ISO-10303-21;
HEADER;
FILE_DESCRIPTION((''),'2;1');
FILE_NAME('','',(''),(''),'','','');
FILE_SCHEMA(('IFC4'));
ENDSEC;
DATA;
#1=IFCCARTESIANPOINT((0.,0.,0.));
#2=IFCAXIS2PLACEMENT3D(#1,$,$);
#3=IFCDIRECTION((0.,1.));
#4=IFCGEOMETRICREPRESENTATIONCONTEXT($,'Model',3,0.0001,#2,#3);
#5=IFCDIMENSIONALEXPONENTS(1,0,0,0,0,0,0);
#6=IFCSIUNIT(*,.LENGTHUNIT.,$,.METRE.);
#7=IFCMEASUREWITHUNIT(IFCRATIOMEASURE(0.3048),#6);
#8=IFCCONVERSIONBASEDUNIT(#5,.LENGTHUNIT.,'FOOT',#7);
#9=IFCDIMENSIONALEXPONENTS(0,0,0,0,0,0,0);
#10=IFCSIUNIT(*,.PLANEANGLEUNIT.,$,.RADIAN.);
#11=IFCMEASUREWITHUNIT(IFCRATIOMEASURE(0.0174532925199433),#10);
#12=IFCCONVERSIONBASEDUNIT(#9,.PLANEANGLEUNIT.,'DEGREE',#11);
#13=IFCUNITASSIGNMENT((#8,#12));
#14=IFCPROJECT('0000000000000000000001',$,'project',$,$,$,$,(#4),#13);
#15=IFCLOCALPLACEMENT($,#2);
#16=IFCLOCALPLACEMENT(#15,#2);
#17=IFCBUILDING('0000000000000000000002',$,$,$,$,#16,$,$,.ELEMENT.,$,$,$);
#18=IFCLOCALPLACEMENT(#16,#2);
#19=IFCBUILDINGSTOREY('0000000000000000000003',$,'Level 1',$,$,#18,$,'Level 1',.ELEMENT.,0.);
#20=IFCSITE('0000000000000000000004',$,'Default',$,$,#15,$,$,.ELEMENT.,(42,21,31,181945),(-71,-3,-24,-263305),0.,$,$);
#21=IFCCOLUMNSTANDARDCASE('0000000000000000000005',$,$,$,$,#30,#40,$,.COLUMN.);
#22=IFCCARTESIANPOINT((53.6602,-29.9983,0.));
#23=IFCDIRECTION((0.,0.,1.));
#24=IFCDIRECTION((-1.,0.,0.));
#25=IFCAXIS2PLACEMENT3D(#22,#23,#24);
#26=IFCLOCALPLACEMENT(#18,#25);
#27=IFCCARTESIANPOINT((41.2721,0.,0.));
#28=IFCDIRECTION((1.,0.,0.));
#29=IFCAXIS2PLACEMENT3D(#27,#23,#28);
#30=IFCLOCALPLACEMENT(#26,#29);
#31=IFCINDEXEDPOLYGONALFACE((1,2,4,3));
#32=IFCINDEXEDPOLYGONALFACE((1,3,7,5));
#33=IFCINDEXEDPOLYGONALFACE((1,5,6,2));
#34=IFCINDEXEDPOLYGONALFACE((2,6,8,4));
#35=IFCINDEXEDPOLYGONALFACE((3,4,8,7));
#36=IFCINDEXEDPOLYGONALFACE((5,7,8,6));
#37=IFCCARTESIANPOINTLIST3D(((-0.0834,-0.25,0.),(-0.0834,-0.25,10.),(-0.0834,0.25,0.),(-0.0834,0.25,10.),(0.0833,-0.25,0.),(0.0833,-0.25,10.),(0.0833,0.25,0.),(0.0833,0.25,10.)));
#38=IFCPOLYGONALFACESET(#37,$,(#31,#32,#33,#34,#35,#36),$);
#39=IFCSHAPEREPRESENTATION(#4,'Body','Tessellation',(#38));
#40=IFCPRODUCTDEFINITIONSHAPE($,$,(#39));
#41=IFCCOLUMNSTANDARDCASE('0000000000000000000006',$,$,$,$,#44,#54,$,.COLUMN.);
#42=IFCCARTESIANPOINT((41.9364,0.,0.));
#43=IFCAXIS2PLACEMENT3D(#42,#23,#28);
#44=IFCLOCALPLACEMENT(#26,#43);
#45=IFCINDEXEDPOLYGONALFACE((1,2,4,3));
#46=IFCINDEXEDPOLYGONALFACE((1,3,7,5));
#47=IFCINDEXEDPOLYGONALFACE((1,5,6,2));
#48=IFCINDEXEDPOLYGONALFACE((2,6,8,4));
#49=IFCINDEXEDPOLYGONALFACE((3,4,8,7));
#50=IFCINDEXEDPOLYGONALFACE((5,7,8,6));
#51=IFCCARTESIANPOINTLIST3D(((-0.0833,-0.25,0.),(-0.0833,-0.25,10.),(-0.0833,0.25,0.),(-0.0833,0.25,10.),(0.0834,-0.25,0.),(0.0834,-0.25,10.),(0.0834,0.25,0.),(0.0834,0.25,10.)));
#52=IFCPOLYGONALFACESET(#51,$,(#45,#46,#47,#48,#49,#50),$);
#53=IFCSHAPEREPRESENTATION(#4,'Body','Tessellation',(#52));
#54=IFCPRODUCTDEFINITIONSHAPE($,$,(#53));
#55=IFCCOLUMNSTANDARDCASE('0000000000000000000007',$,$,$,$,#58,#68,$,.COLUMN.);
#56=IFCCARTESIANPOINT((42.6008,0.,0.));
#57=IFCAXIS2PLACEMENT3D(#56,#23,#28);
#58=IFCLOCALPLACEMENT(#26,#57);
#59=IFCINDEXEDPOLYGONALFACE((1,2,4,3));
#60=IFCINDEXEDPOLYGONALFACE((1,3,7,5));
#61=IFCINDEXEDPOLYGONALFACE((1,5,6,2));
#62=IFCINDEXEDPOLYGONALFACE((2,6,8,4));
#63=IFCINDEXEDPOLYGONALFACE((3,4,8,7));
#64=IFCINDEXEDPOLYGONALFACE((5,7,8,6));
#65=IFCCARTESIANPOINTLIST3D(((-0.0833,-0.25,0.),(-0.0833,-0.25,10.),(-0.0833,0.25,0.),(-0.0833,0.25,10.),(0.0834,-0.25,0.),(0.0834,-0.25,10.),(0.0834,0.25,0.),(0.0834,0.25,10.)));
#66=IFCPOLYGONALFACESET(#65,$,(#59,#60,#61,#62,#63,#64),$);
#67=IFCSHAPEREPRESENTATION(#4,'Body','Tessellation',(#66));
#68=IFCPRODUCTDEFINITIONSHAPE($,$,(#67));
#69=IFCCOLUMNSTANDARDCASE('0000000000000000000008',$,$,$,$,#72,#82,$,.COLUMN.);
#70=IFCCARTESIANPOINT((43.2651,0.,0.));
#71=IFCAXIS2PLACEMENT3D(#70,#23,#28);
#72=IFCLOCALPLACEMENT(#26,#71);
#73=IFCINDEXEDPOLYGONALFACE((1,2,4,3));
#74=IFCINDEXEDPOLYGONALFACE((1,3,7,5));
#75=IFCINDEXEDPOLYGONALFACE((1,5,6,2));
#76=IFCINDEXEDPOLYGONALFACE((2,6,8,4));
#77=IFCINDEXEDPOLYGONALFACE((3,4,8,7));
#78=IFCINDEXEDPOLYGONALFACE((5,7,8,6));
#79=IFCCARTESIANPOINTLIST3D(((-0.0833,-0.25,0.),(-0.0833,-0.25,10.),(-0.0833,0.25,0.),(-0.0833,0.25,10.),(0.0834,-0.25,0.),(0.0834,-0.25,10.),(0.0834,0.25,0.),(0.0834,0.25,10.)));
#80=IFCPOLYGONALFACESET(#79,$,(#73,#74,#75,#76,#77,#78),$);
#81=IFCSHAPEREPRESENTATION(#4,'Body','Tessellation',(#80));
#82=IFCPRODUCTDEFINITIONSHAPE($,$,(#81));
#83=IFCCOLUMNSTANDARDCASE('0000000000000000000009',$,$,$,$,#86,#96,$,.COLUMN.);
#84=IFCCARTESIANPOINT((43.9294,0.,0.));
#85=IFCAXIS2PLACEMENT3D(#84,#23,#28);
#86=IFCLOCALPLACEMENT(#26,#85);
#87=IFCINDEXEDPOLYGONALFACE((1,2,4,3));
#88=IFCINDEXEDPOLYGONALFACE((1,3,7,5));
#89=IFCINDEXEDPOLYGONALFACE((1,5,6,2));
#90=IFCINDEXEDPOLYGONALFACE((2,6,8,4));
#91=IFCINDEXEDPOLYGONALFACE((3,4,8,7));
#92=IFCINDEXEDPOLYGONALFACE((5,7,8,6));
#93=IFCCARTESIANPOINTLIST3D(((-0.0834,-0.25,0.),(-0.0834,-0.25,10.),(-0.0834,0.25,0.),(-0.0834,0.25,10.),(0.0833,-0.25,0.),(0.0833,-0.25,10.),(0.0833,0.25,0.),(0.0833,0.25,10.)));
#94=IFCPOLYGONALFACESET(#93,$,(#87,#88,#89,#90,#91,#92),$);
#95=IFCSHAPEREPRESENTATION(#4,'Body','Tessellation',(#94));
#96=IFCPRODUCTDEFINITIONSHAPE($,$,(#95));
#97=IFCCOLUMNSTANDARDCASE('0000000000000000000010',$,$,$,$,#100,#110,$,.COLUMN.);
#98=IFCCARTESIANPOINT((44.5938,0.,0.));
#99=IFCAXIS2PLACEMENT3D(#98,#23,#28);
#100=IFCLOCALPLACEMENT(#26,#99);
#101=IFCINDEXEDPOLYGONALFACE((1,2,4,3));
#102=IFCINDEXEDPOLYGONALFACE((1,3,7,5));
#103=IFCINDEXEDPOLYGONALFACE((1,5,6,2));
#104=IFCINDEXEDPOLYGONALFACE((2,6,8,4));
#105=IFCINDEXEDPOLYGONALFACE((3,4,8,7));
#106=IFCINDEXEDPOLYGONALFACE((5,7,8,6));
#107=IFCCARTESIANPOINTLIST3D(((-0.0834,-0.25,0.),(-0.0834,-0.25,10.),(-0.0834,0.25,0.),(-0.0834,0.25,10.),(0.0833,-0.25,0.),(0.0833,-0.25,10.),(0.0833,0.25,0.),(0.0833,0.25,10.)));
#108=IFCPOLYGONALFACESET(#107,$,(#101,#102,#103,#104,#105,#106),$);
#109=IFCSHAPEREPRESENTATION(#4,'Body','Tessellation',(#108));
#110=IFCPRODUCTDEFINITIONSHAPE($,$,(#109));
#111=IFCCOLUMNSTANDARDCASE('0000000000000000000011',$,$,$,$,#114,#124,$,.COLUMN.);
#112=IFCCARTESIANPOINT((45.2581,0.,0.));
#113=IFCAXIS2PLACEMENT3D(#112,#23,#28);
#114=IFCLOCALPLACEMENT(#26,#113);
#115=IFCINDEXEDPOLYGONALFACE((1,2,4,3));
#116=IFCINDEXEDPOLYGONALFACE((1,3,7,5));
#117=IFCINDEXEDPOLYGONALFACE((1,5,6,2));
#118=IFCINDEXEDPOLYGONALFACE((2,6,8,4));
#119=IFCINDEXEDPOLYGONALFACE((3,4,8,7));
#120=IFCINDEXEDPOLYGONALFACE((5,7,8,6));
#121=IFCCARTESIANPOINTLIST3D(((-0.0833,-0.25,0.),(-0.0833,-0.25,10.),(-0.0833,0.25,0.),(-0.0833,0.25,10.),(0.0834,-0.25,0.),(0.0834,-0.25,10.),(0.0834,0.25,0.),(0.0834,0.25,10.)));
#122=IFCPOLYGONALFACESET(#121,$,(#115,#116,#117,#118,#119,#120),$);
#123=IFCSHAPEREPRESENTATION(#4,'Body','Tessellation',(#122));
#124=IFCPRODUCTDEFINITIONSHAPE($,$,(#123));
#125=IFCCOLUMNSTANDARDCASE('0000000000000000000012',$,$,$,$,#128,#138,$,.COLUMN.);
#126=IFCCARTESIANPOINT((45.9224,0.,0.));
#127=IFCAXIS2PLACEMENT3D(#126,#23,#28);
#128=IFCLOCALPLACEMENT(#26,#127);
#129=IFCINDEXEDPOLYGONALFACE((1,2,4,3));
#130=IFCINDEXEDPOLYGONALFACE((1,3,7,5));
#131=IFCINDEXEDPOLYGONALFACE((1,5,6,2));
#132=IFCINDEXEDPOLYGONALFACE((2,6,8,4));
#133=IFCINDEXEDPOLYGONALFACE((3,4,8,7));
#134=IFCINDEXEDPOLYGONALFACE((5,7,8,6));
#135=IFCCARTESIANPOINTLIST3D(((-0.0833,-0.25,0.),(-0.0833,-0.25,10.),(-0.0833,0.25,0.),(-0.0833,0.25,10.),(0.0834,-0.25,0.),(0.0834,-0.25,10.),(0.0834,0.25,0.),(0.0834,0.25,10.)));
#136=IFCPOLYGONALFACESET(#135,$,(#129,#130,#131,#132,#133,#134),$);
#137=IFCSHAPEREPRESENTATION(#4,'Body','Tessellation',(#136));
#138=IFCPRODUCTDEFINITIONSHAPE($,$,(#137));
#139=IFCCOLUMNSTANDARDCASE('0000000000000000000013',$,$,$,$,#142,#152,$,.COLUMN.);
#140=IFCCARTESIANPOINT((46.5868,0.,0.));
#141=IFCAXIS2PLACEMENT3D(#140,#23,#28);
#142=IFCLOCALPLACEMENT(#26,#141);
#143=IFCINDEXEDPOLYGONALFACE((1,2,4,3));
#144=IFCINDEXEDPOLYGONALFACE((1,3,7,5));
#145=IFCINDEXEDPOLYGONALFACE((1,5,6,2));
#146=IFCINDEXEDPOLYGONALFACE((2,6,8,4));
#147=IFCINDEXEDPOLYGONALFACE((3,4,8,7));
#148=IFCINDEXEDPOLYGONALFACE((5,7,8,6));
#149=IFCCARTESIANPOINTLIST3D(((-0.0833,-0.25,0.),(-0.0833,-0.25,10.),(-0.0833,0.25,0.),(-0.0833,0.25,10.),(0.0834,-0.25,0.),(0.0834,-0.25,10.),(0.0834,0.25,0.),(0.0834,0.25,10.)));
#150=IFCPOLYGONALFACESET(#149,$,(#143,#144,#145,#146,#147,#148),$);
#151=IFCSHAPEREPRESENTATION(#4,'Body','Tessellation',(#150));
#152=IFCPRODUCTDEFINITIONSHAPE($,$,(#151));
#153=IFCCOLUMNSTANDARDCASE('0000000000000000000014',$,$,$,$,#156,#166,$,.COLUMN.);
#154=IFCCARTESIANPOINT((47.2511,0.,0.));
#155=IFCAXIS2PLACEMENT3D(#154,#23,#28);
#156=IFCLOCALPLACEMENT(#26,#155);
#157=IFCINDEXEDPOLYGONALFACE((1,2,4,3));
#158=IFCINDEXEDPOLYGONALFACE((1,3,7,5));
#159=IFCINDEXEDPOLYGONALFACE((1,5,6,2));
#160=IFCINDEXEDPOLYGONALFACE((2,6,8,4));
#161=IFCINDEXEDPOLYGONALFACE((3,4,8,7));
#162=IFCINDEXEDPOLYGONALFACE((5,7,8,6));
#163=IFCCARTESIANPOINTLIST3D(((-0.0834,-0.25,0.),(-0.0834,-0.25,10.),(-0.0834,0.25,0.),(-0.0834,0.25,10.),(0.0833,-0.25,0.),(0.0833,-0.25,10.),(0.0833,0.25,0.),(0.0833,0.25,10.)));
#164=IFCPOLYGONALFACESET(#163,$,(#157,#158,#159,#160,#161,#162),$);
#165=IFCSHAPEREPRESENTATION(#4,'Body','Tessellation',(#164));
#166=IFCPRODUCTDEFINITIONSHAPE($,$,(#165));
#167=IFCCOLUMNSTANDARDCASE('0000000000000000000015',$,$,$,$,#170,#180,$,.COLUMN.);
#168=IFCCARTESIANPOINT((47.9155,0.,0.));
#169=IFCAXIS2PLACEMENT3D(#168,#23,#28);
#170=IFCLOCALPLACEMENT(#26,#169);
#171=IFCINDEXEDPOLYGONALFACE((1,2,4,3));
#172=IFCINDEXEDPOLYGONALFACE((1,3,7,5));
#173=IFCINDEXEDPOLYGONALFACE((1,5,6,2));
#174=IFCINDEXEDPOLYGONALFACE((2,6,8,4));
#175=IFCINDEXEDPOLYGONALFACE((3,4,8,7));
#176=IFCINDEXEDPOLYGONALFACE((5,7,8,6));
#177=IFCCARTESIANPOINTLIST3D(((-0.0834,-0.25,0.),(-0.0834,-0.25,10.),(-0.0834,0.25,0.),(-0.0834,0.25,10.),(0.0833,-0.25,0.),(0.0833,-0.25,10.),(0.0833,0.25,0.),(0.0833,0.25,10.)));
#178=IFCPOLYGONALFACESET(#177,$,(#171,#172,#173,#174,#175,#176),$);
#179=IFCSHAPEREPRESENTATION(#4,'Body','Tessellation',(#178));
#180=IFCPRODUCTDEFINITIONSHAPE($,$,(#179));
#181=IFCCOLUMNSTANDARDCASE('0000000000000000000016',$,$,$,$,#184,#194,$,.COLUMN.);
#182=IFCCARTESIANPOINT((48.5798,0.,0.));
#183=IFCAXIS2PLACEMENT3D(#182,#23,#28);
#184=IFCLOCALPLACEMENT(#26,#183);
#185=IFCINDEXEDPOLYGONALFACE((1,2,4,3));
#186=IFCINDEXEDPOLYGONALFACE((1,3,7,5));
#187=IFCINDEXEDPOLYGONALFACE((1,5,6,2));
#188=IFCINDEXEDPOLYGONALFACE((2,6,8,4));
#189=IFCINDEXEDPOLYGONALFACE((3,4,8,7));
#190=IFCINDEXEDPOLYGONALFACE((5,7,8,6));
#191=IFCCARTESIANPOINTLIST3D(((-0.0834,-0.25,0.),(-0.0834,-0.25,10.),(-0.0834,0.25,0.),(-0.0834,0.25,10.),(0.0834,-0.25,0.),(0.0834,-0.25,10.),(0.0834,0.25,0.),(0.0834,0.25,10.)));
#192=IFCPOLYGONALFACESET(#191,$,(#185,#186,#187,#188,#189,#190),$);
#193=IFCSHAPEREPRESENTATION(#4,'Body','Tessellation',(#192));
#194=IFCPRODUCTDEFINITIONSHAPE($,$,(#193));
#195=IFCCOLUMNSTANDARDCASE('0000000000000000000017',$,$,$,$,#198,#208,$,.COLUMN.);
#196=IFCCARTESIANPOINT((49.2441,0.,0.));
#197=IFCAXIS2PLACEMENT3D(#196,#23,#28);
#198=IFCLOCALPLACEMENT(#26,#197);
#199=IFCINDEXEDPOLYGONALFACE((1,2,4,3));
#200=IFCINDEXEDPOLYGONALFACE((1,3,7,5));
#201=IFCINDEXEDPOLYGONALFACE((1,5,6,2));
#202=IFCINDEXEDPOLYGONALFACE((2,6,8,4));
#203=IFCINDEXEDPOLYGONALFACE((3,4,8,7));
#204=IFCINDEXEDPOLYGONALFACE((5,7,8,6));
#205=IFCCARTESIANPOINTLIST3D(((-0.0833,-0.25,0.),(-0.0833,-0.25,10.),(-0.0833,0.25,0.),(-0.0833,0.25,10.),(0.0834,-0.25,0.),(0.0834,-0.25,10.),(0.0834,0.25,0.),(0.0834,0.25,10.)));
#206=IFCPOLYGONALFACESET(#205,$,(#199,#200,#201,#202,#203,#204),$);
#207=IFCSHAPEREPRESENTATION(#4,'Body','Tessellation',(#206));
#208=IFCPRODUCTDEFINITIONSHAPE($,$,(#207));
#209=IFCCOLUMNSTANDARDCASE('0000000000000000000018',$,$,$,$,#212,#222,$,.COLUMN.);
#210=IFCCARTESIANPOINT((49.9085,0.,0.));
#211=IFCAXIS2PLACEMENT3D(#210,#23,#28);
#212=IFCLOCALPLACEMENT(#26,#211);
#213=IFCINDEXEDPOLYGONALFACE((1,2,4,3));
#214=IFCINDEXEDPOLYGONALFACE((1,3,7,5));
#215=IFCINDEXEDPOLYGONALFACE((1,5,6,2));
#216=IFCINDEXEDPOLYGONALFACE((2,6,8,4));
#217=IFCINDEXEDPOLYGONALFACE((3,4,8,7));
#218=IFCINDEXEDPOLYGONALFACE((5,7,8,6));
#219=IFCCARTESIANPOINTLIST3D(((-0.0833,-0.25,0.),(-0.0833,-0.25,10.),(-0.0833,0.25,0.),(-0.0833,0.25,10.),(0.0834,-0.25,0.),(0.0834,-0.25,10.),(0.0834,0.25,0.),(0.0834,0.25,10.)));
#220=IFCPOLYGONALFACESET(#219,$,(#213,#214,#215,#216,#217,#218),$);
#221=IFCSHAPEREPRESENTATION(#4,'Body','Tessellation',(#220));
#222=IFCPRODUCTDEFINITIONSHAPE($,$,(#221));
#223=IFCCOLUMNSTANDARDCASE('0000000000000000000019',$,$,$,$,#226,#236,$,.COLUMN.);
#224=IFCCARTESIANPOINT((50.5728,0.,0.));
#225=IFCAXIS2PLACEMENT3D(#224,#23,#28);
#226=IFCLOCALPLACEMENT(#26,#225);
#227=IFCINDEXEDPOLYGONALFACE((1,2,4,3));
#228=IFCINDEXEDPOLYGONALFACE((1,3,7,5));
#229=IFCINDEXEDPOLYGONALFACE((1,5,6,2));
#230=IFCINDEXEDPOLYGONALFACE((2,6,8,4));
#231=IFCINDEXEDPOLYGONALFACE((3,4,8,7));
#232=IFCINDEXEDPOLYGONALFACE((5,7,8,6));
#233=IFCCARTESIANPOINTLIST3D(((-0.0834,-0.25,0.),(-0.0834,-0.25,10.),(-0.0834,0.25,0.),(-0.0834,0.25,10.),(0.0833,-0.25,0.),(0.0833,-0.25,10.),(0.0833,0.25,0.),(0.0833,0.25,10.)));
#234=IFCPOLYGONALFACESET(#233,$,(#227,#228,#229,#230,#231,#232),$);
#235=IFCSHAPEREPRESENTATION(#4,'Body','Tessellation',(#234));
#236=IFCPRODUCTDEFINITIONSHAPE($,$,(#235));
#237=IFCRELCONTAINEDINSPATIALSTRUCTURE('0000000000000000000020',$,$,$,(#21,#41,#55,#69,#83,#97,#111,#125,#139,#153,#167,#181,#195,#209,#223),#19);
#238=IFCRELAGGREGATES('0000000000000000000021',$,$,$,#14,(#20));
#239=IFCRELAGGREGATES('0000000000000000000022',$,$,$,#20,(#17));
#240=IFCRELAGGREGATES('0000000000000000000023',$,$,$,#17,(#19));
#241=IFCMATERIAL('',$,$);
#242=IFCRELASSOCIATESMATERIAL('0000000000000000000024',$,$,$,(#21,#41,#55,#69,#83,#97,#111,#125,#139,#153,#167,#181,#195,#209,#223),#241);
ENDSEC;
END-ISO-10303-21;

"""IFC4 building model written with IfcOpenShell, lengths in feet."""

from ifc_helpers import new_model, entity, si_unit, converted_unit, direction, frame, origin, place, context, project, spatial, rectangle, extrude, material, element, save


model = new_model("IFC4")

# Units and contexts
model_context = context("Model", 3, precision=0.0001, world=origin(), true_north=direction((0.0, 1.0)))
ifc_project = project(units=[converted_unit("LENGTHUNIT", "FOOT", entity("IfcRatioMeasure", 0.3048), si_unit("LENGTHUNIT", "METRE"), dimensions=[1, 0, 0, 0, 0, 0, 0]), converted_unit("PLANEANGLEUNIT", "DEGREE", entity("IfcRatioMeasure", 0.0174532925199433), si_unit("PLANEANGLEUNIT", "RADIAN"), dimensions=[0, 0, 0, 0, 0, 0, 0])], contexts=[model_context])

# Site, building, storey
site_placement = place(None, origin())
site = spatial("IfcSite", under=ifc_project, at=site_placement, Name="Default", CompositionType="ELEMENT", RefLatitude=(42, 21, 31, 181945), RefLongitude=(-71, -3, -24, -263305), RefElevation=0.0)
building_placement = place(site_placement, origin())
building = spatial("IfcBuilding", under=site, at=building_placement, CompositionType="ELEMENT")
storey_placement = place(building_placement, origin())
storey = spatial("IfcBuildingStorey", under=building, at=storey_placement, Name="Level 1", LongName="Level 1", CompositionType="ELEMENT", Elevation=0.0)

# Columns
ifc_material_1 = material(Name="")
placement = place(storey_placement, frame((53.6602, -29.9983, 0.0), z_axis=(0.0, 0.0, 1.0), x_axis=(-1.0, 0.0, 0.0)))
for number, where, z_axis, x_axis in (
    (1, (41.2721, 0.0, 0.0), (0.0, 0.0, 1.0), (1.0, 0.0, 0.0)),
    (2, (41.9364, 0.0, 0.0), (0.0, 0.0, 1.0), (1.0, 0.0, 0.0)),
    (3, (42.6008, 0.0, 0.0), (0.0, 0.0, 1.0), (1.0, 0.0, 0.0)),
    (4, (43.2651, 0.0, 0.0), (0.0, 0.0, 1.0), (1.0, 0.0, 0.0)),
    (5, (43.9294, 0.0, 0.0), (0.0, 0.0, 1.0), (1.0, 0.0, 0.0)),
    (6, (44.5938, 0.0, 0.0), (0.0, 0.0, 1.0), (1.0, 0.0, 0.0)),
    (7, (45.2581, 0.0, 0.0), (0.0, 0.0, 1.0), (1.0, 0.0, 0.0)),
    (8, (45.9224, 0.0, 0.0), (0.0, 0.0, 1.0), (1.0, 0.0, 0.0)),
    (9, (46.5868, 0.0, 0.0), (0.0, 0.0, 1.0), (1.0, 0.0, 0.0)),
    (10, (47.2511, 0.0, 0.0), (0.0, 0.0, 1.0), (1.0, 0.0, 0.0)),
    (11, (47.9155, 0.0, 0.0), (0.0, 0.0, 1.0), (1.0, 0.0, 0.0)),
    (12, (48.5798, 0.0, 0.0), (0.0, 0.0, 1.0), (1.0, 0.0, 0.0)),
    (13, (49.2441, 0.0, 0.0), (0.0, 0.0, 1.0), (1.0, 0.0, 0.0)),
    (14, (49.9085, 0.0, 0.0), (0.0, 0.0, 1.0), (1.0, 0.0, 0.0)),
    (15, (50.5728, 0.0, 0.0), (0.0, 0.0, 1.0), (1.0, 0.0, 0.0)),
):
    element("IfcColumnStandardCase", number, at=place(placement, frame(where, z_axis=z_axis, x_axis=x_axis)), inside=storey, material=ifc_material_1, PredefinedType="COLUMN", context=model_context, shape_type="SweptSolid", body=[
        extrude(rectangle(XDim=0.1667, YDim=0.5), origin(), (0.0, 0.0, 1.0), 10.0),
    ])

save(model, "model.ifc")
